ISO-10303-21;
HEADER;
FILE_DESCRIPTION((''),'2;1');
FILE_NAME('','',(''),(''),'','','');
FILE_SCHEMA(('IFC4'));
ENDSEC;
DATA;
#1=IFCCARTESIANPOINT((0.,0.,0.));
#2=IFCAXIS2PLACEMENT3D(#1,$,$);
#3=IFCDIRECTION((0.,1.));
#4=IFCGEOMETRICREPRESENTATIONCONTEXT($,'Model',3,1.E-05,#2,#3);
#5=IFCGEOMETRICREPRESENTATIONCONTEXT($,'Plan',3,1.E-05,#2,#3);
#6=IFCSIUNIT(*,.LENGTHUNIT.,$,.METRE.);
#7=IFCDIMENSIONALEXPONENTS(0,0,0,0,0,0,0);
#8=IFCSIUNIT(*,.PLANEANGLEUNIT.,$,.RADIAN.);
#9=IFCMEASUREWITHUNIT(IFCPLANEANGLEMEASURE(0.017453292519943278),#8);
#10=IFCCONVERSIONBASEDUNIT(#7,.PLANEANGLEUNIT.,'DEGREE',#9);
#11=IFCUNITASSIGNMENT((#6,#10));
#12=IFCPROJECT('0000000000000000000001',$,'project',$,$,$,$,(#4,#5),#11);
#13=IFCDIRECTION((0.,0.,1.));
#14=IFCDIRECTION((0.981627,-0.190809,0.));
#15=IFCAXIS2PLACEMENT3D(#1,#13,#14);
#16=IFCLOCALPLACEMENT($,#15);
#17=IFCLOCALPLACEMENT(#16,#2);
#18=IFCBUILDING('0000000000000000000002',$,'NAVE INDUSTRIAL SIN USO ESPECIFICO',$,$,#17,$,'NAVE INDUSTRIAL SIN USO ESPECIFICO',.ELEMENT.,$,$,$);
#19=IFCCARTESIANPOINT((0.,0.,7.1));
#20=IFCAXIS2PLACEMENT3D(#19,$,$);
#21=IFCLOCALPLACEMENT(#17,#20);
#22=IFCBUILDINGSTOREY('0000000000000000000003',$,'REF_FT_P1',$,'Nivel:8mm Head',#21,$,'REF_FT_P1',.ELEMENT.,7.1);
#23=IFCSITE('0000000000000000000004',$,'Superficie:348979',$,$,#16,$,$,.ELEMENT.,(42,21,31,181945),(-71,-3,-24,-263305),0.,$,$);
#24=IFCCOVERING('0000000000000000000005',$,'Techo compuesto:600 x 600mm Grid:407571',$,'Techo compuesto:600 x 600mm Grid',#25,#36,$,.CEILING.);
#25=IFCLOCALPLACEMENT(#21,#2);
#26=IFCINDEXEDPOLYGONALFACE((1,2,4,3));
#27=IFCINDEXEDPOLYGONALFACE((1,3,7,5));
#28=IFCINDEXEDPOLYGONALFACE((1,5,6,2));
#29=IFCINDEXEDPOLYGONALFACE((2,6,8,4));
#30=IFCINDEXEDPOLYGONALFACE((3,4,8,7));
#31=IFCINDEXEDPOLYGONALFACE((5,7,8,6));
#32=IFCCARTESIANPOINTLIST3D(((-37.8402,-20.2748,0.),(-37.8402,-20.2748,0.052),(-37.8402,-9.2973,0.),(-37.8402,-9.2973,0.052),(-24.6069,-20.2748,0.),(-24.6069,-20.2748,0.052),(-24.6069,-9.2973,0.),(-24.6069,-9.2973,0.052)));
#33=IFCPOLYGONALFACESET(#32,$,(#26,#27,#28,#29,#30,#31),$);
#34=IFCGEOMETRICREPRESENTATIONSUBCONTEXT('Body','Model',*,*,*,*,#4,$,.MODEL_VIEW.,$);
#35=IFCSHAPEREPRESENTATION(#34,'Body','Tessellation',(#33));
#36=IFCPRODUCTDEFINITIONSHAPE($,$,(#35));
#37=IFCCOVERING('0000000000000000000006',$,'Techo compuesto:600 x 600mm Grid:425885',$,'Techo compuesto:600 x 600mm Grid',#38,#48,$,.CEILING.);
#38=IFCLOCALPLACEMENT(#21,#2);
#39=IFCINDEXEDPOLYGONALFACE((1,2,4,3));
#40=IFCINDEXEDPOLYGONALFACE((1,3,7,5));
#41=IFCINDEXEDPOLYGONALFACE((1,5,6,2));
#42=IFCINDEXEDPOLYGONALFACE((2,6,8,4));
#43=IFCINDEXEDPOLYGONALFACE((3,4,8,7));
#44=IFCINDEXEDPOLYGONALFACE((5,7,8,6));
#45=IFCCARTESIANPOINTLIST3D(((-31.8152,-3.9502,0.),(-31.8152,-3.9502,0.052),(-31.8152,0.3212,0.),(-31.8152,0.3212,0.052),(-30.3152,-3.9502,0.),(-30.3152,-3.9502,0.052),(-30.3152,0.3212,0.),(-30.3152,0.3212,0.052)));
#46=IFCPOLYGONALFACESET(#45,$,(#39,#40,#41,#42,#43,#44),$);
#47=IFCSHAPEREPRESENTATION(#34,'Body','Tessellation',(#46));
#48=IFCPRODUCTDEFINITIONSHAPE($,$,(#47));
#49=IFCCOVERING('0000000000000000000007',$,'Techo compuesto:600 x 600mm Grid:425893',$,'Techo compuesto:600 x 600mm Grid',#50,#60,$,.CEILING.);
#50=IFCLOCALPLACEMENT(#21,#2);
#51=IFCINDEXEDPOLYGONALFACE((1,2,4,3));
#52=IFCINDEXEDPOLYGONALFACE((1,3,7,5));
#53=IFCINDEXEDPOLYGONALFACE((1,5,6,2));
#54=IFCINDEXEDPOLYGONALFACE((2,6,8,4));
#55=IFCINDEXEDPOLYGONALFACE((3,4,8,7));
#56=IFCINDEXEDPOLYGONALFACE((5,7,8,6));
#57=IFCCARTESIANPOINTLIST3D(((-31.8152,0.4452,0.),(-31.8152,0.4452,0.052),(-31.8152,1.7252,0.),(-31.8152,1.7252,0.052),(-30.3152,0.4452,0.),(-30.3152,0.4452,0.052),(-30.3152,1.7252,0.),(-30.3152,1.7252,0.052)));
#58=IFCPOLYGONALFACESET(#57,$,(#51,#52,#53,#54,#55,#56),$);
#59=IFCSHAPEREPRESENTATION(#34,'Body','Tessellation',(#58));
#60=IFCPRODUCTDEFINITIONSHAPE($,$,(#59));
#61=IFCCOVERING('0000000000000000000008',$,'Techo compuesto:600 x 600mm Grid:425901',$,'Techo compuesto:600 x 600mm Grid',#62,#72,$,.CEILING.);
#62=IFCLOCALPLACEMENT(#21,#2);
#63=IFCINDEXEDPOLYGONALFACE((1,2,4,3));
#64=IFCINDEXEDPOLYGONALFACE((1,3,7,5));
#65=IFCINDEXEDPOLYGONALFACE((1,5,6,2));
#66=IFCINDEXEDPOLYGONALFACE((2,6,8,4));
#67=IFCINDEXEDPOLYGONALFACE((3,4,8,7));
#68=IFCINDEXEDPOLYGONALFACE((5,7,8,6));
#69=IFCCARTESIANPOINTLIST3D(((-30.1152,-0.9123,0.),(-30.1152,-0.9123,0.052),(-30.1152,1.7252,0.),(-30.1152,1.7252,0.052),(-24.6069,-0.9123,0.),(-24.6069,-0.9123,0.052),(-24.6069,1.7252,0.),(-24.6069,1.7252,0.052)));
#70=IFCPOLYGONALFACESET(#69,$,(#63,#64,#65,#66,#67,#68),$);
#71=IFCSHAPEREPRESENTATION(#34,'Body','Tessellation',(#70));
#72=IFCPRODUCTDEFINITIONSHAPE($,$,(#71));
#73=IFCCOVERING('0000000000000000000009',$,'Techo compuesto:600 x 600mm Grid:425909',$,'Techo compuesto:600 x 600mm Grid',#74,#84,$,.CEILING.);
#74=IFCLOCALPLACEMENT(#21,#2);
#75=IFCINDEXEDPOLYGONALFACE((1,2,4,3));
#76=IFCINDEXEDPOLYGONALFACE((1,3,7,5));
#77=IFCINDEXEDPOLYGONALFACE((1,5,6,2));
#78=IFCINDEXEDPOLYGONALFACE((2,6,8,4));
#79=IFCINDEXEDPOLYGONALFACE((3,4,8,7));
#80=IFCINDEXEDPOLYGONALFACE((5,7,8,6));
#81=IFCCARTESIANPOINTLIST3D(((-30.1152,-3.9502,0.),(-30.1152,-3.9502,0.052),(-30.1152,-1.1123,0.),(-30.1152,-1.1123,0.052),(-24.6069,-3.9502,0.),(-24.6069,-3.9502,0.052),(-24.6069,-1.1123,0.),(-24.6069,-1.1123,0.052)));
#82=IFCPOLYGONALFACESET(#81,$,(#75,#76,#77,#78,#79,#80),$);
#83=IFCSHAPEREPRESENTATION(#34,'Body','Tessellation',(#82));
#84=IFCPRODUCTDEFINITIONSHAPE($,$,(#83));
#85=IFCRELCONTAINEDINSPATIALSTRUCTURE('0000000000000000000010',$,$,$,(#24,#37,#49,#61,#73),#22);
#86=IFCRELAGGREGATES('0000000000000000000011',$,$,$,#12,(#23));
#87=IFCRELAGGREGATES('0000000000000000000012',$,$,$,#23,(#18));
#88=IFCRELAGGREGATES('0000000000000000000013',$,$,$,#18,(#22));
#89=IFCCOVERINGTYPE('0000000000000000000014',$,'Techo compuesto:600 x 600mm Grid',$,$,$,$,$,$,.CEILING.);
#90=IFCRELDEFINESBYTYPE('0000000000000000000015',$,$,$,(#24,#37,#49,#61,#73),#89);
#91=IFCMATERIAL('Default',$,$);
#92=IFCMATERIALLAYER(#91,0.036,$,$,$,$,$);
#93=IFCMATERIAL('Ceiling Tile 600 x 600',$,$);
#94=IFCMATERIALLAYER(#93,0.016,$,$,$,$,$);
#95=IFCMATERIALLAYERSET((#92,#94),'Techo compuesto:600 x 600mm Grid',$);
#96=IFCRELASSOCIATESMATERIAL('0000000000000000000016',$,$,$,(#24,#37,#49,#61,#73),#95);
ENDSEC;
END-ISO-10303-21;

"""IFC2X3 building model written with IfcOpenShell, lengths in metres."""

from ifc_helpers import new_model, entity, si_unit, converted_unit, direction, frame, frame_2d, origin, place, context, subcontext, project, spatial, rectangle, extrude, material, layer, layer_set, layer_usage, type_object, element, save


model = new_model("IFC2X3")

# Units and contexts
model_context = context("Model", 3, precision=1e-05, world=origin(), true_north=direction((0.0, 1.0)))
plan_context = context("Plan", 3, precision=1e-05, world=origin(), true_north=direction((0.0, 1.0)))
body_context = subcontext(model_context, "Body", "Model", "MODEL_VIEW")
ifc_project = project(units=[si_unit("LENGTHUNIT", "METRE"), converted_unit("PLANEANGLEUNIT", "DEGREE", entity("IfcPlaneAngleMeasure", 0.017453292519943278), si_unit("PLANEANGLEUNIT", "RADIAN"), dimensions=[0, 0, 0, 0, 0, 0, 0])], contexts=[model_context, plan_context])

# Site, building, storey
site_placement = place(None, frame((0.0, 0.0, 0.0), z_axis=(0.0, 0.0, 1.0), x_axis=(0.981627, -0.190809, 0.0)))
site = spatial("IfcSite", under=ifc_project, at=site_placement, Name="Superficie:348979", CompositionType="ELEMENT", RefLatitude=(42, 21, 31, 181945), RefLongitude=(-71, -3, -24, -263305), RefElevation=0.0)
building_placement = place(site_placement, origin())
building = spatial("IfcBuilding", under=site, at=building_placement, Name="NAVE INDUSTRIAL SIN USO ESPECIFICO", LongName="NAVE INDUSTRIAL SIN USO ESPECIFICO", CompositionType="ELEMENT")
storey_placement = place(building_placement, frame((0.0, 0.0, 7.1)))
storey = spatial("IfcBuildingStorey", under=building, at=storey_placement, Name="REF_FT_P1", ObjectType="Nivel:8mm Head", LongName="REF_FT_P1", CompositionType="ELEMENT", Elevation=7.1)

# Coverings
ifc_material_1 = material(Name="Default")
ifc_layer_1 = layer(ifc_material_1, 0.036)
ifc_material_2 = material(Name="Ceiling Tile 600 x 600")
ifc_layer_2 = layer(ifc_material_2, 0.016)
ifc_layer_set = layer_set([ifc_layer_1, ifc_layer_2], Name="Techo compuesto:600 x 600mm Grid")
covering_type = type_object("IfcCoveringType", Name="Techo compuesto:600 x 600mm Grid", PredefinedType="CEILING")
ifc_layer_usage_1 = layer_usage(ifc_layer_set, "AXIS3", "NEGATIVE", 0.052)
covering_1_placement = place(storey_placement, frame((-37.8402, -20.2748, 0.0)))
element("IfcCovering", 1, at=covering_1_placement, inside=storey, type_object=covering_type, material=ifc_layer_usage_1, Name="Techo compuesto:600 x 600mm Grid:407571", ObjectType="Techo compuesto:600 x 600mm Grid", PredefinedType="CEILING", context=body_context, shape_type="SweptSolid", body=[
    extrude(rectangle(XDim=13.2333, YDim=10.9775, at=frame_2d((0.0, 0.0), x_axis=(1.0, 0.0))), frame((6.6167, 5.4888, 0.0)), (0.0, 0.0, 1.0), 0.052),
])
ifc_layer_usage_2 = layer_usage(ifc_layer_set, "AXIS3", "NEGATIVE", 0.052)
covering_2_placement = place(storey_placement, frame((-31.8152, -3.9502, 0.0)))
element("IfcCovering", 2, at=covering_2_placement, inside=storey, type_object=covering_type, material=ifc_layer_usage_2, Name="Techo compuesto:600 x 600mm Grid:425885", ObjectType="Techo compuesto:600 x 600mm Grid", PredefinedType="CEILING", context=body_context, shape_type="SweptSolid", body=[
    extrude(rectangle(XDim=1.5, YDim=4.2714, at=frame_2d((0.0, 0.0), x_axis=(1.0, 0.0))), frame((0.75, 2.1357, 0.0), z_axis=(0.0, 0.0, 1.0), x_axis=(-1.0, 0.0, 0.0)), (0.0, 0.0, 1.0), 0.052),
])
ifc_layer_usage_3 = layer_usage(ifc_layer_set, "AXIS3", "NEGATIVE", 0.052)
covering_3_placement = place(storey_placement, frame((-31.8152, 0.4452, 0.0)))
element("IfcCovering", 3, at=covering_3_placement, inside=storey, type_object=covering_type, material=ifc_layer_usage_3, Name="Techo compuesto:600 x 600mm Grid:425893", ObjectType="Techo compuesto:600 x 600mm Grid", PredefinedType="CEILING", context=body_context, shape_type="SweptSolid", body=[
    extrude(rectangle(XDim=1.28, YDim=1.5, at=frame_2d((0.0, 0.0), x_axis=(1.0, 0.0))), frame((0.75, 0.64, 0.0), z_axis=(0.0, 0.0, 1.0), x_axis=(0.0, -1.0, 0.0)), (0.0, 0.0, 1.0), 0.052),
])
ifc_layer_usage_4 = layer_usage(ifc_layer_set, "AXIS3", "NEGATIVE", 0.052)
covering_4_placement = place(storey_placement, frame((-30.1152, -0.9123, 0.0)))
element("IfcCovering", 4, at=covering_4_placement, inside=storey, type_object=covering_type, material=ifc_layer_usage_4, Name="Techo compuesto:600 x 600mm Grid:425901", ObjectType="Techo compuesto:600 x 600mm Grid", PredefinedType="CEILING", context=body_context, shape_type="SweptSolid", body=[
    extrude(rectangle(XDim=2.6375, YDim=5.5083, at=frame_2d((0.0, 0.0), x_axis=(1.0, 0.0))), frame((2.7542, 1.3188, 0.0), z_axis=(0.0, 0.0, 1.0), x_axis=(0.0, -1.0, 0.0)), (0.0, 0.0, 1.0), 0.052),
])
ifc_layer_usage_5 = layer_usage(ifc_layer_set, "AXIS3", "NEGATIVE", 0.052)
covering_5_placement = place(storey_placement, frame((-30.1152, -3.9502, 0.0)))
element("IfcCovering", 5, at=covering_5_placement, inside=storey, type_object=covering_type, material=ifc_layer_usage_5, Name="Techo compuesto:600 x 600mm Grid:425909", ObjectType="Techo compuesto:600 x 600mm Grid", PredefinedType="CEILING", context=body_context, shape_type="SweptSolid", body=[
    extrude(rectangle(XDim=5.5083, YDim=2.8379, at=frame_2d((0.0, 0.0), x_axis=(1.0, 0.0))), frame((2.7542, 1.419, 0.0), z_axis=(0.0, 0.0, 1.0), x_axis=(-1.0, 0.0, 0.0)), (0.0, 0.0, 1.0), 0.052),
])

save(model, "model.ifc")
